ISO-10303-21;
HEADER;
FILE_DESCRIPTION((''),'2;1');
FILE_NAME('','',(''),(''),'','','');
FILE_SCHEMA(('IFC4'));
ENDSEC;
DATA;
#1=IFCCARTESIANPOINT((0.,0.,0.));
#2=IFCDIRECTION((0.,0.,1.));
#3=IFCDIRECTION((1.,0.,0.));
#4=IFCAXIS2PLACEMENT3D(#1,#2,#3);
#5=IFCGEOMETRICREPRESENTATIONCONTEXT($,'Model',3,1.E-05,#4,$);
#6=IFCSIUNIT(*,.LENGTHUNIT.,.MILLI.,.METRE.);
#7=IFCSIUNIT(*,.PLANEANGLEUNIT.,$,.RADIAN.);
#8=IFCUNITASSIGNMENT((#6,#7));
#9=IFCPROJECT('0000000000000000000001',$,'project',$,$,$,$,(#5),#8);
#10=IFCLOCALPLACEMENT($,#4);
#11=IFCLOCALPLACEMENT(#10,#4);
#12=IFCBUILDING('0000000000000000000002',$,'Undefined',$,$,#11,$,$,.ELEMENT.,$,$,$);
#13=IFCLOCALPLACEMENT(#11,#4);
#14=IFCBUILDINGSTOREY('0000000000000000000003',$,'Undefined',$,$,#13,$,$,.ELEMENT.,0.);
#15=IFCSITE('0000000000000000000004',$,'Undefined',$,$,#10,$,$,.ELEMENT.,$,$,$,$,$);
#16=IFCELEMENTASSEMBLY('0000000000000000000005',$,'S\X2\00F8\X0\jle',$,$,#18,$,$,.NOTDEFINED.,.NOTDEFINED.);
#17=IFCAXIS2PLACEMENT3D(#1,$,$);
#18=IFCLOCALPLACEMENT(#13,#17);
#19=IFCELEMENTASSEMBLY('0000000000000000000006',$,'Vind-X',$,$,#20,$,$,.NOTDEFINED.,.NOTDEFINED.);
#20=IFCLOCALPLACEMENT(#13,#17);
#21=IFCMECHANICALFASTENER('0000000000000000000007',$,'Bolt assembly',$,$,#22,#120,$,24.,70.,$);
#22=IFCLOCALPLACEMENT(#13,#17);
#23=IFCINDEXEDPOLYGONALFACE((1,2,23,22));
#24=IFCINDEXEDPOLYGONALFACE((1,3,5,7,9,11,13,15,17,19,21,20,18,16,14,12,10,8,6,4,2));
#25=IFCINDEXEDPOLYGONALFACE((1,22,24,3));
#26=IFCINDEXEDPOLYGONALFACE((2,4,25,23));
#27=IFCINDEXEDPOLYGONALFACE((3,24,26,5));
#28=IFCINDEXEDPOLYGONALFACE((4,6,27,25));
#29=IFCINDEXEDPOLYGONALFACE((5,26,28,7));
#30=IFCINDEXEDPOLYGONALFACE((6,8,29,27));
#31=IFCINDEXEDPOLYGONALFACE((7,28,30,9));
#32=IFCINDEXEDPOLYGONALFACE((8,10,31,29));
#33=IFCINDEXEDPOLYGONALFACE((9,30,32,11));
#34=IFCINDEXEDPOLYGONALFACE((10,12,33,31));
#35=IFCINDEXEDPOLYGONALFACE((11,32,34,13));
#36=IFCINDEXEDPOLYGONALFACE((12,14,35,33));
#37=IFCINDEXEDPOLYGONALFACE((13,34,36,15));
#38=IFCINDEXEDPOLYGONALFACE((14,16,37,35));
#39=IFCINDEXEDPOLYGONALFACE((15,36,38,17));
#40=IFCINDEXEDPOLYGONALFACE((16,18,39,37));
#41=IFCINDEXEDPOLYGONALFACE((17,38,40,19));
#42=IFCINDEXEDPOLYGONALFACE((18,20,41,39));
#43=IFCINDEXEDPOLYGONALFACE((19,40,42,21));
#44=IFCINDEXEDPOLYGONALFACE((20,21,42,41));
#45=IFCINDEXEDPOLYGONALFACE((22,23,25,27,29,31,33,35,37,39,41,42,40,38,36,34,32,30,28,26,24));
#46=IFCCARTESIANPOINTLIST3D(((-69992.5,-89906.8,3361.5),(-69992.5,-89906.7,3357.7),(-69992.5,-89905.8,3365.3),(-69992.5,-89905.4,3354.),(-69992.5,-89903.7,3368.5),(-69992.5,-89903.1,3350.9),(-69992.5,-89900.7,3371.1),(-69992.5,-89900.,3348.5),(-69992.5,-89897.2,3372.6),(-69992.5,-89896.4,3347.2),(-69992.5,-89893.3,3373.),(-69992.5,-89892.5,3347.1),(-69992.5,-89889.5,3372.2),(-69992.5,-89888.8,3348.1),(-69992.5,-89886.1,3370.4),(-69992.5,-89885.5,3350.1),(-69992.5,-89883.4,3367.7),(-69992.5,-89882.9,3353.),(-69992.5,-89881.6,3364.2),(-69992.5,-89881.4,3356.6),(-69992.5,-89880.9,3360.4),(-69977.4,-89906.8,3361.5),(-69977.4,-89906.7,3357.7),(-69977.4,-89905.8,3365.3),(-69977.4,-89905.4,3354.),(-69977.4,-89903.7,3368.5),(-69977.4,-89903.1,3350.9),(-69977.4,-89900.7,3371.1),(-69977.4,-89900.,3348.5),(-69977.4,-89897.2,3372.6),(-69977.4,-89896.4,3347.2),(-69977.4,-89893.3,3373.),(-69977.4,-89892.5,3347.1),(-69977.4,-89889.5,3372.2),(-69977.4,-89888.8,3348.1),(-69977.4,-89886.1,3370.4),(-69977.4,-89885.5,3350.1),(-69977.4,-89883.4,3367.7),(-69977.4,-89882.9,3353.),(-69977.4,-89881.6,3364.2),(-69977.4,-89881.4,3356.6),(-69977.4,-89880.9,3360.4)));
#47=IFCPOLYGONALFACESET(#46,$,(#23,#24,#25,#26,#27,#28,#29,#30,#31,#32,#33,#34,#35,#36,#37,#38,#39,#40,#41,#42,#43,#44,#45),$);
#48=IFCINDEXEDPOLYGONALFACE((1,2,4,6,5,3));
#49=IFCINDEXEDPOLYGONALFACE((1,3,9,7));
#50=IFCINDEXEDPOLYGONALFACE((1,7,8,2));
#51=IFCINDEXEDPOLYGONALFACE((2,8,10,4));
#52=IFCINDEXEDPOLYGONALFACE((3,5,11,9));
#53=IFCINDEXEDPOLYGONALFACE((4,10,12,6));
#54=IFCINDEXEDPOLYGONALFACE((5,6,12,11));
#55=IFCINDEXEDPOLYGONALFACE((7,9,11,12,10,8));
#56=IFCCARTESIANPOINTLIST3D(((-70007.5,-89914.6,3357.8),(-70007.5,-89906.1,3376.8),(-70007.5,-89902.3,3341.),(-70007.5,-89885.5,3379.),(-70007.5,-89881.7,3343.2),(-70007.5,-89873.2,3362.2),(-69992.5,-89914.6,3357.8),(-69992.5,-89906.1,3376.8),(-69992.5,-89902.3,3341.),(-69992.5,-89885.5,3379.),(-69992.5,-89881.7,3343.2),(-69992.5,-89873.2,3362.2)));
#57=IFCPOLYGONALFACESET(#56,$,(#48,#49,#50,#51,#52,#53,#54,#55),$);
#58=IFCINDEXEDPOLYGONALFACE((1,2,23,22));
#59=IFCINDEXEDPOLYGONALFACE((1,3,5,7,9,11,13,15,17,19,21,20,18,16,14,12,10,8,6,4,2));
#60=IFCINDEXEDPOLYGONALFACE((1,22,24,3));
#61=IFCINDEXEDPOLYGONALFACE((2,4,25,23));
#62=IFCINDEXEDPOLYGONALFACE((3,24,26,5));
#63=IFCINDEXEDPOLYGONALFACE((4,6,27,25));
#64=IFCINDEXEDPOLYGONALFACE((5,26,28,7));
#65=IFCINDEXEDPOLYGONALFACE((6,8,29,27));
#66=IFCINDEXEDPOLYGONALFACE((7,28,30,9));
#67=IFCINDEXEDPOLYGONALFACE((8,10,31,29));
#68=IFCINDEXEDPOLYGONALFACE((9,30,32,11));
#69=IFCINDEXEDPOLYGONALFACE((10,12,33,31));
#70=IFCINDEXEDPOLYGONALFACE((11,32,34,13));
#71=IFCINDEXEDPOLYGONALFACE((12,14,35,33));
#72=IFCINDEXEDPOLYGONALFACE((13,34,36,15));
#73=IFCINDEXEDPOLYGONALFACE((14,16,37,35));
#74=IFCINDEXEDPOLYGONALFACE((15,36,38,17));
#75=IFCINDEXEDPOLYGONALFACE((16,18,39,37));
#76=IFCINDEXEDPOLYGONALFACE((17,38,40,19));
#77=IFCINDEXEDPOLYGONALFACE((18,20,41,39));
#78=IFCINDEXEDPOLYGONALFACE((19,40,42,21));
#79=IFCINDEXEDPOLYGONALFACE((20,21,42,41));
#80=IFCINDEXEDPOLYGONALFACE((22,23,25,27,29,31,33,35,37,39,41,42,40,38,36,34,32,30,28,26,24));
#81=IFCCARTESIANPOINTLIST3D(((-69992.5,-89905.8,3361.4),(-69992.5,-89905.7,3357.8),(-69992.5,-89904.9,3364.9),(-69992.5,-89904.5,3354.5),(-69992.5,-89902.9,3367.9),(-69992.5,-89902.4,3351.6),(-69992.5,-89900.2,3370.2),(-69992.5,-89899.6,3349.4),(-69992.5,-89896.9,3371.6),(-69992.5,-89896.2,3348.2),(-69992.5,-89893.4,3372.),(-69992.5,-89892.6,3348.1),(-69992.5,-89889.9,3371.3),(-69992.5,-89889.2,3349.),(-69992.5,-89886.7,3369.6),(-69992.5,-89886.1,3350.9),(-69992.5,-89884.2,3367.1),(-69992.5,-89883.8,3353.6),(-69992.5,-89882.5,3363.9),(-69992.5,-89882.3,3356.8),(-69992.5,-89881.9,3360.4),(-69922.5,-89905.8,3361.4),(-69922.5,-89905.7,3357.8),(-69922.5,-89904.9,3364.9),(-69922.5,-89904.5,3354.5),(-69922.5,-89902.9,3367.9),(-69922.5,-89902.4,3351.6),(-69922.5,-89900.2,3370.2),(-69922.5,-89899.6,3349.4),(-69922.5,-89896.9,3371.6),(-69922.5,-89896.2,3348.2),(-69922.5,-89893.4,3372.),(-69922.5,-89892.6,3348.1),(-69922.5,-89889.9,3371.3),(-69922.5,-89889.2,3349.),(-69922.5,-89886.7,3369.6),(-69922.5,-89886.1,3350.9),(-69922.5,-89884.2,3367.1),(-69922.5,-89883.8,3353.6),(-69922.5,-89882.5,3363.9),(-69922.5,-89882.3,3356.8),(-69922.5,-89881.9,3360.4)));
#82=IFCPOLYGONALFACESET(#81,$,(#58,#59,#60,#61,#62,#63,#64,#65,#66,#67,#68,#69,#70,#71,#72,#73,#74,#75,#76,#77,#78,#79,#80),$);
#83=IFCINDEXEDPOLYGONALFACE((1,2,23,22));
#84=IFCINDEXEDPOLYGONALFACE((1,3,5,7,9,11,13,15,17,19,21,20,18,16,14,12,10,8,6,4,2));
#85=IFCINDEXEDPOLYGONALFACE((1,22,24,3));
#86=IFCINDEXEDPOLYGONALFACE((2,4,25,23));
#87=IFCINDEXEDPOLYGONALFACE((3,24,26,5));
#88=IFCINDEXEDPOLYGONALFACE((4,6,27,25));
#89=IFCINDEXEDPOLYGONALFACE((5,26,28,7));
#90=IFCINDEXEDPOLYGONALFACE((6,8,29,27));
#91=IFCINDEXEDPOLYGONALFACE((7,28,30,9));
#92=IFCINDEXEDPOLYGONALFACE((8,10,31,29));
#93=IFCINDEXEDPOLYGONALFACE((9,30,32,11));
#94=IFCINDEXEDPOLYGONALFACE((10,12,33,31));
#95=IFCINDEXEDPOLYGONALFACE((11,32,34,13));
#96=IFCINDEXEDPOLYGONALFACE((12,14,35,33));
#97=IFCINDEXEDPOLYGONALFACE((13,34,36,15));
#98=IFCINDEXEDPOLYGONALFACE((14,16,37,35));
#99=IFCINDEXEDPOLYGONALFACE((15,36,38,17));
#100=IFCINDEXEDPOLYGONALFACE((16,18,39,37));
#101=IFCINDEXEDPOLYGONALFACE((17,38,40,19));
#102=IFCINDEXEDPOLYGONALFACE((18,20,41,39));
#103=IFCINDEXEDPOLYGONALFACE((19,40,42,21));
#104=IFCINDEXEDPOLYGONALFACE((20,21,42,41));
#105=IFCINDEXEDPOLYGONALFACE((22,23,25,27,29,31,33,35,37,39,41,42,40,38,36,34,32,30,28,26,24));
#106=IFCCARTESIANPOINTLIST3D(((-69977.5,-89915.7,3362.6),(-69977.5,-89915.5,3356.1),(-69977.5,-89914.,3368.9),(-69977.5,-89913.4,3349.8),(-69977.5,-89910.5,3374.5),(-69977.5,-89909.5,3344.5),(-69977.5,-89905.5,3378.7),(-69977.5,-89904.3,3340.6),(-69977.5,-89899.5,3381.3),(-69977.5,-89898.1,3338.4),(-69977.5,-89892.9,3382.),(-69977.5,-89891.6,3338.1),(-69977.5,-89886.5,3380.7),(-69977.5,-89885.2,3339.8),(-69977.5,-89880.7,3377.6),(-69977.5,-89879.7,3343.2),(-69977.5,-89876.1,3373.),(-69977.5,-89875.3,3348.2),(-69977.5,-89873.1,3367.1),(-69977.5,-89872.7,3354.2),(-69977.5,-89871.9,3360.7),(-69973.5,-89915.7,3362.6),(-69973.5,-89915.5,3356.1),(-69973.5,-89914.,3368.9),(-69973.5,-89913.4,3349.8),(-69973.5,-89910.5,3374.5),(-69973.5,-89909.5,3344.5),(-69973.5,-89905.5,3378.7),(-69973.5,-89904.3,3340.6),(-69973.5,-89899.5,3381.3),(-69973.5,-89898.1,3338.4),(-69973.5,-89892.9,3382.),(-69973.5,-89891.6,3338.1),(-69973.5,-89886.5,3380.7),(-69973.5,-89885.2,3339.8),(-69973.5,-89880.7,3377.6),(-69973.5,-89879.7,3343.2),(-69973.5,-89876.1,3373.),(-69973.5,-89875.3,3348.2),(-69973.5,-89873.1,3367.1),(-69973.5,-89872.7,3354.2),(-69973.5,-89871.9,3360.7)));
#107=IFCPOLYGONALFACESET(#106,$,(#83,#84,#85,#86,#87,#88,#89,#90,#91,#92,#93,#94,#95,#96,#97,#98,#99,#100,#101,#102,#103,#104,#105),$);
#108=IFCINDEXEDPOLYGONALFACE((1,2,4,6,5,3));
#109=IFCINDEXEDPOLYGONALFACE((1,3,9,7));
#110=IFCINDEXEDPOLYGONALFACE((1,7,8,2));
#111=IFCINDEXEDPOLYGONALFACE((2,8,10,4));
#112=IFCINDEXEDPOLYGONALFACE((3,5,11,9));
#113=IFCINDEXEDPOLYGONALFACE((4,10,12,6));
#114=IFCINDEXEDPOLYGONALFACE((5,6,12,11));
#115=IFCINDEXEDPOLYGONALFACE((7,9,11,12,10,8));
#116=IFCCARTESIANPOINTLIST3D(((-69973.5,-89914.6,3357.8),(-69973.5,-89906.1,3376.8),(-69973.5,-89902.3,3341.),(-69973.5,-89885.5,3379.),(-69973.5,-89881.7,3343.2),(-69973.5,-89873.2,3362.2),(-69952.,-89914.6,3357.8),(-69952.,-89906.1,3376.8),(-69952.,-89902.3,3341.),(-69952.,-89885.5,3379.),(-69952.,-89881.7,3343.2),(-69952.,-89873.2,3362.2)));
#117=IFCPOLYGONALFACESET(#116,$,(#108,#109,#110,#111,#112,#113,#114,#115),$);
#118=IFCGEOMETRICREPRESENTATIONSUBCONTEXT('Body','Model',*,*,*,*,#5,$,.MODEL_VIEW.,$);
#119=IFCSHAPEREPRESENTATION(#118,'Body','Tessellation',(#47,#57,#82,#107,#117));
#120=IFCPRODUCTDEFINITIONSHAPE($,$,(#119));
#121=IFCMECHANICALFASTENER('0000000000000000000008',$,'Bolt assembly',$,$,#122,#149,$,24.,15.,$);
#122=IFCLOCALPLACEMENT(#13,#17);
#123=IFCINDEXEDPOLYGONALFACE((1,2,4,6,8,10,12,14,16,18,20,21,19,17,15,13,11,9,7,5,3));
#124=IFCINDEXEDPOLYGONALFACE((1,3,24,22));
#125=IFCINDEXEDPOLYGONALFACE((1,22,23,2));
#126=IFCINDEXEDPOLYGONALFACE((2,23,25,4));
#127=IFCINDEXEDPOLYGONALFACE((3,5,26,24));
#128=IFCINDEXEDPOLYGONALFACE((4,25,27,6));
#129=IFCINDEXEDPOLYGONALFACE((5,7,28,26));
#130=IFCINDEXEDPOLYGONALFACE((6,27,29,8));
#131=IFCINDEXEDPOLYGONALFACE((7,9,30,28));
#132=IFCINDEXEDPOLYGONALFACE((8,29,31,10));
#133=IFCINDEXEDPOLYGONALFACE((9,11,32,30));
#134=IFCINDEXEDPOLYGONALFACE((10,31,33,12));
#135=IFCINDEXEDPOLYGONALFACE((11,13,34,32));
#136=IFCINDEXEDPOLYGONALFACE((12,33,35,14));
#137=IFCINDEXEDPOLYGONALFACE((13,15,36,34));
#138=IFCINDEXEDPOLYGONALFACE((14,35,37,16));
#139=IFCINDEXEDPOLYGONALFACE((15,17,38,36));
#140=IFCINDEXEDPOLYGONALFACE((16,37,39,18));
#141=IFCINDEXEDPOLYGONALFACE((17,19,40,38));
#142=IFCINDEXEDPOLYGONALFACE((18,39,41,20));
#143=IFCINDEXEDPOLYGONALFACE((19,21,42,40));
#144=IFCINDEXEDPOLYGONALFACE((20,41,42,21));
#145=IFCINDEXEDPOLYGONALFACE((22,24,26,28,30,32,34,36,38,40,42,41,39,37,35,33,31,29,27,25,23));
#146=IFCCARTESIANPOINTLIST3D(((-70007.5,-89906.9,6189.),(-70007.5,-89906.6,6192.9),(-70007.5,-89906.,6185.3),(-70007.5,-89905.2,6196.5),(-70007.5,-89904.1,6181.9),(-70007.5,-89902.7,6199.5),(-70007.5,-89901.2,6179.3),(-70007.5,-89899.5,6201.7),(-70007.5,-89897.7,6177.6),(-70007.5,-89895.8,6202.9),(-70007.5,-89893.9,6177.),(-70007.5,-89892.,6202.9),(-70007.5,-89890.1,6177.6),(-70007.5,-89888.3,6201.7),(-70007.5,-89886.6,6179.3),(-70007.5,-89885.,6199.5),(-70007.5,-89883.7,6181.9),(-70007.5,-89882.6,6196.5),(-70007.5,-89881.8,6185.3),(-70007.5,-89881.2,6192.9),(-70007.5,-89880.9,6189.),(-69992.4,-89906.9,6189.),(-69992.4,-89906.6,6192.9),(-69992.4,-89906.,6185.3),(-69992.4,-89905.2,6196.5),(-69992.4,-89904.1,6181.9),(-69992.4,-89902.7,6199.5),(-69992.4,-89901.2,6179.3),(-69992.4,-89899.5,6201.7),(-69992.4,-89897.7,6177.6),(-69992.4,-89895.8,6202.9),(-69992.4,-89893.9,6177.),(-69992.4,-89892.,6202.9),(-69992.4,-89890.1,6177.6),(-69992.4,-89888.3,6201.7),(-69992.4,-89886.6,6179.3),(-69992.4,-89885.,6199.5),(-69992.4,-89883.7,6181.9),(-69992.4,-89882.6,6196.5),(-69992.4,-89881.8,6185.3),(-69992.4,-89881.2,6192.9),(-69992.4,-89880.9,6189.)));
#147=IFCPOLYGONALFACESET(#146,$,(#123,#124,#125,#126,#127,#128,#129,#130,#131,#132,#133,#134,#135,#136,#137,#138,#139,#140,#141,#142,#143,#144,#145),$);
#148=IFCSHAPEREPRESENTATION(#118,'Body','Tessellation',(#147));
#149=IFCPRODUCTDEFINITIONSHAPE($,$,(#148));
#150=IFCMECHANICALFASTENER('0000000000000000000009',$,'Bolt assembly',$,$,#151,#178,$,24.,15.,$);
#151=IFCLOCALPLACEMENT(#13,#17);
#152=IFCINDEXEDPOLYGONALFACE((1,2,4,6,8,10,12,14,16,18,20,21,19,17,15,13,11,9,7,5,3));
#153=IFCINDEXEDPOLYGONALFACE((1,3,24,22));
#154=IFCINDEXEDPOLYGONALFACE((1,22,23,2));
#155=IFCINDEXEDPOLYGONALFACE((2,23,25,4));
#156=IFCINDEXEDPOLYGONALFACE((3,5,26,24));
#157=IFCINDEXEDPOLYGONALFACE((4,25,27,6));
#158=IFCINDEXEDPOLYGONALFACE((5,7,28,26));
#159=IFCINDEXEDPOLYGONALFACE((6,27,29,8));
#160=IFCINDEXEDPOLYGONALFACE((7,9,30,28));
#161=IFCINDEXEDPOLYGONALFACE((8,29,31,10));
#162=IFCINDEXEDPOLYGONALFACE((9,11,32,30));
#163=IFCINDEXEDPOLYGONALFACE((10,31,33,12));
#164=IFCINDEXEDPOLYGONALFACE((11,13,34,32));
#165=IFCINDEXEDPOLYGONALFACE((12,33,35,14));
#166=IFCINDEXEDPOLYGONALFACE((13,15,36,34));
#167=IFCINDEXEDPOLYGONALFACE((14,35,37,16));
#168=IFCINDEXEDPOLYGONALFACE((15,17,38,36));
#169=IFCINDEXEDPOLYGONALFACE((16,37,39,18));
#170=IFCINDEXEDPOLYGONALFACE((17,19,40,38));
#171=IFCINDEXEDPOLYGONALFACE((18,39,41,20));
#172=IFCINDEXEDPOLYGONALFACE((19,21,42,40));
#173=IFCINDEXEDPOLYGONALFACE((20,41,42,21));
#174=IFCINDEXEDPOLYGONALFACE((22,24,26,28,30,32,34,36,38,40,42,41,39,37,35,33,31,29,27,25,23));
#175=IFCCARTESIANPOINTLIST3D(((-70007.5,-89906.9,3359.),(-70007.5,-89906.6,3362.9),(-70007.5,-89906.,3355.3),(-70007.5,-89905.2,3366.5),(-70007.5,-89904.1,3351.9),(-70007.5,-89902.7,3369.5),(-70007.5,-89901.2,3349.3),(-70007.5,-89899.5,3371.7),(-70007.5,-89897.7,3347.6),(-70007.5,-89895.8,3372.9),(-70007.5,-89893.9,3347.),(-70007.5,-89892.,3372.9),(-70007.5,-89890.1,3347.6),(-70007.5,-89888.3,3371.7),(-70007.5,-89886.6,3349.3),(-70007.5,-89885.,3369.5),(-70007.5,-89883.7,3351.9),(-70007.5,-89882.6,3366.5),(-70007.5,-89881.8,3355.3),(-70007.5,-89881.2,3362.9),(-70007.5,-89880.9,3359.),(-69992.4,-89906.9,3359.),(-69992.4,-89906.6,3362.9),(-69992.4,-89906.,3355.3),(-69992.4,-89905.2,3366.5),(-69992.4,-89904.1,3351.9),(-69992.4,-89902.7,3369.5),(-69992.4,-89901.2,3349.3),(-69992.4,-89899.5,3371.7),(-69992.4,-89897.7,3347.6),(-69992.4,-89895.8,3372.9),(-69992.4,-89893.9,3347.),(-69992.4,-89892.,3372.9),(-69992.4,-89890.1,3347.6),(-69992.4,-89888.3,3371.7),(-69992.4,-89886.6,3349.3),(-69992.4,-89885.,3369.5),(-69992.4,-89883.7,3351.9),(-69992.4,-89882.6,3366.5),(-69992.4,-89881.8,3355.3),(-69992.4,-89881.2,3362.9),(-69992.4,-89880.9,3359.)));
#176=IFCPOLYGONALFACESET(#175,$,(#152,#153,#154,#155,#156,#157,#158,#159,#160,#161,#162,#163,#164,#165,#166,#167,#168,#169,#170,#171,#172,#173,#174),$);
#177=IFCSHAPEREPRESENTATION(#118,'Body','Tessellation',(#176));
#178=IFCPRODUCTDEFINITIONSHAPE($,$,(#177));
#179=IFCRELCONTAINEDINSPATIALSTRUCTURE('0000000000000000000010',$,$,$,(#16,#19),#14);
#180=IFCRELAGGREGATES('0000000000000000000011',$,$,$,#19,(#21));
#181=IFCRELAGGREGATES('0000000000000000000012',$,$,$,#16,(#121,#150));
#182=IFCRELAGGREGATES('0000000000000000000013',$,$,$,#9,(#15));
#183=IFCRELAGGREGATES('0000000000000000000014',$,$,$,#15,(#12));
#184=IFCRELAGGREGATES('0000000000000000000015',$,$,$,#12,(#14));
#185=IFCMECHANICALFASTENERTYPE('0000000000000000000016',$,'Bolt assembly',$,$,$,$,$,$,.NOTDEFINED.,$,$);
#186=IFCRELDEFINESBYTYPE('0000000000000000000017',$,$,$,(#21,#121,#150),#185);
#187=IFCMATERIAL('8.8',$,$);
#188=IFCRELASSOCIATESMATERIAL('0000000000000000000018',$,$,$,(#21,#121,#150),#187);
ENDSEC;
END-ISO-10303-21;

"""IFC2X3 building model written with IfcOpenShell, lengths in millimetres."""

from ifc_helpers import new_model, si_unit, frame, origin_with_axes, origin_2d_with_axis, place, context, subcontext, project, spatial, polyline, circle, outline, extrude, source, transform, mapped, material, type_object, element, aggregate, save


model = new_model("IFC2X3")

# Units and contexts
model_context = context("Model", 3, precision=1e-05, world=origin_with_axes())
body_context = subcontext(model_context, "Body", "Model", "MODEL_VIEW")
ifc_project = project(units=[si_unit("LENGTHUNIT", "METRE", prefix="MILLI"), si_unit("PLANEANGLEUNIT", "RADIAN")], contexts=[model_context])

# Site, building, storey
site_placement = place(None, origin_with_axes())
site = spatial("IfcSite", under=ifc_project, at=site_placement, Name="Undefined", CompositionType="ELEMENT")
building_placement = place(site_placement, origin_with_axes())
building = spatial("IfcBuilding", under=site, at=building_placement, Name="Undefined", CompositionType="ELEMENT")
storey_placement = place(building_placement, origin_with_axes())
storey = spatial("IfcBuildingStorey", under=building, at=storey_placement, Name="Undefined", CompositionType="ELEMENT", Elevation=0.0)

# Element assembly
assembly_1_placement = place(storey_placement, origin_with_axes())
assembly_1 = element("IfcElementAssembly", 1, at=assembly_1_placement, inside=storey, Name="Søjle", AssemblyPlace="NOTDEFINED", PredefinedType="NOTDEFINED")

# Element assembly
assembly_2_placement = place(storey_placement, origin_with_axes())
assembly_2 = element("IfcElementAssembly", 2, at=assembly_2_placement, inside=storey, Name="Vind-X", AssemblyPlace="NOTDEFINED", PredefinedType="NOTDEFINED")

# Mechanical fasteners
ifc_material_1 = material(Name="8.8")
mechanical_fastener_type = type_object("IfcMechanicalFastenerType", Name="Bolt assembly")
shared_shape_1 = source(origin_with_axes(), body_context, "Body", "SweptSolid", [
    extrude(circle(Radius=13.0, at=origin_2d_with_axis()), frame((0.0, 0.0, 0.0), z_axis=(0.0, 1.0, 0.0), x_axis=(1.0, 0.0, 0.0)), (0.0, 0.0, 1.0), 15.1),
    extrude(outline(polyline([(18.0, -10.4), (18.0, 10.4), (0.0, 20.8), (-18.0, 10.4), (-18.0, -10.4), (0.0, -20.8), (18.0, -10.4)])), frame((0.0, -15.0, 0.0), z_axis=(0.0, 1.0, 0.0), x_axis=(1.0, 0.0, 0.0)), (0.0, 0.0, 1.0), 15.0),
    extrude(circle(Radius=12.0, at=origin_2d_with_axis()), frame((0.0, 0.0, 0.0), z_axis=(0.0, 1.0, 0.0), x_axis=(1.0, 0.0, 0.0)), (0.0, 0.0, 1.0), 70.0),
    extrude(circle(Radius=22.0, at=origin_2d_with_axis()), frame((0.0, 15.0, 0.0), z_axis=(0.0, 1.0, 0.0), x_axis=(1.0, 0.0, 0.0)), (0.0, 0.0, 1.0), 4.0),
    extrude(outline(polyline([(18.0, -10.4), (18.0, 10.4), (0.0, 20.8), (-18.0, 10.4), (-18.0, -10.4), (0.0, -20.8), (18.0, -10.4)])), frame((0.0, 19.0, 0.0), z_axis=(0.0, 1.0, 0.0), x_axis=(1.0, 0.0, 0.0)), (0.0, 0.0, 1.0), 21.5),
])
mechanical_fastener_1_placement = place(assembly_2_placement, frame((-69992.5, -89893.9, 3360.0), z_axis=(0.0, 0.588616, -0.808413), x_axis=(0.0, 0.808413, 0.588616)))
mechanical_fastener_1 = element("IfcMechanicalFastener", 3, at=mechanical_fastener_1_placement, type_object=mechanical_fastener_type, material=ifc_material_1, Name="Bolt assembly", NominalDiameter=24.0, NominalLength=70.0, context=body_context, shape_type="MappedRepresentation", body=[
    mapped(shared_shape_1, transform((0.0, 0.0, 0.0))),
])
aggregate(assembly_2, [mechanical_fastener_1])
shared_shape_2 = source(origin_with_axes(), body_context, "Body", "SweptSolid", [
    extrude(circle(Radius=13.0, at=origin_2d_with_axis()), frame((0.0, -7.5, 0.0), z_axis=(0.0, 1.0, 0.0), x_axis=(1.0, 0.0, 0.0)), (0.0, 0.0, 1.0), 15.1),
])
mechanical_fastener_2_placement = place(assembly_1_placement, frame((-70000.0, -89893.9, 6190.0), z_axis=(0.0, -1.0, 0.0), x_axis=(0.0, 0.0, -1.0)))
mechanical_fastener_2 = element("IfcMechanicalFastener", 4, at=mechanical_fastener_2_placement, type_object=mechanical_fastener_type, material=ifc_material_1, Name="Bolt assembly", NominalDiameter=24.0, NominalLength=15.0, context=body_context, shape_type="MappedRepresentation", body=[
    mapped(shared_shape_2, transform((0.0, 0.0, 0.0))),
])
mechanical_fastener_3_placement = place(assembly_1_placement, frame((-70000.0, -89893.9, 3360.0), z_axis=(0.0, -1.0, 0.0), x_axis=(0.0, 0.0, -1.0)))
mechanical_fastener_3 = element("IfcMechanicalFastener", 5, at=mechanical_fastener_3_placement, type_object=mechanical_fastener_type, material=ifc_material_1, Name="Bolt assembly", NominalDiameter=24.0, NominalLength=15.0, context=body_context, shape_type="MappedRepresentation", body=[
    mapped(shared_shape_2, transform((0.0, 0.0, 0.0))),
])
aggregate(assembly_1, [mechanical_fastener_2, mechanical_fastener_3])

save(model, "model.ifc")
